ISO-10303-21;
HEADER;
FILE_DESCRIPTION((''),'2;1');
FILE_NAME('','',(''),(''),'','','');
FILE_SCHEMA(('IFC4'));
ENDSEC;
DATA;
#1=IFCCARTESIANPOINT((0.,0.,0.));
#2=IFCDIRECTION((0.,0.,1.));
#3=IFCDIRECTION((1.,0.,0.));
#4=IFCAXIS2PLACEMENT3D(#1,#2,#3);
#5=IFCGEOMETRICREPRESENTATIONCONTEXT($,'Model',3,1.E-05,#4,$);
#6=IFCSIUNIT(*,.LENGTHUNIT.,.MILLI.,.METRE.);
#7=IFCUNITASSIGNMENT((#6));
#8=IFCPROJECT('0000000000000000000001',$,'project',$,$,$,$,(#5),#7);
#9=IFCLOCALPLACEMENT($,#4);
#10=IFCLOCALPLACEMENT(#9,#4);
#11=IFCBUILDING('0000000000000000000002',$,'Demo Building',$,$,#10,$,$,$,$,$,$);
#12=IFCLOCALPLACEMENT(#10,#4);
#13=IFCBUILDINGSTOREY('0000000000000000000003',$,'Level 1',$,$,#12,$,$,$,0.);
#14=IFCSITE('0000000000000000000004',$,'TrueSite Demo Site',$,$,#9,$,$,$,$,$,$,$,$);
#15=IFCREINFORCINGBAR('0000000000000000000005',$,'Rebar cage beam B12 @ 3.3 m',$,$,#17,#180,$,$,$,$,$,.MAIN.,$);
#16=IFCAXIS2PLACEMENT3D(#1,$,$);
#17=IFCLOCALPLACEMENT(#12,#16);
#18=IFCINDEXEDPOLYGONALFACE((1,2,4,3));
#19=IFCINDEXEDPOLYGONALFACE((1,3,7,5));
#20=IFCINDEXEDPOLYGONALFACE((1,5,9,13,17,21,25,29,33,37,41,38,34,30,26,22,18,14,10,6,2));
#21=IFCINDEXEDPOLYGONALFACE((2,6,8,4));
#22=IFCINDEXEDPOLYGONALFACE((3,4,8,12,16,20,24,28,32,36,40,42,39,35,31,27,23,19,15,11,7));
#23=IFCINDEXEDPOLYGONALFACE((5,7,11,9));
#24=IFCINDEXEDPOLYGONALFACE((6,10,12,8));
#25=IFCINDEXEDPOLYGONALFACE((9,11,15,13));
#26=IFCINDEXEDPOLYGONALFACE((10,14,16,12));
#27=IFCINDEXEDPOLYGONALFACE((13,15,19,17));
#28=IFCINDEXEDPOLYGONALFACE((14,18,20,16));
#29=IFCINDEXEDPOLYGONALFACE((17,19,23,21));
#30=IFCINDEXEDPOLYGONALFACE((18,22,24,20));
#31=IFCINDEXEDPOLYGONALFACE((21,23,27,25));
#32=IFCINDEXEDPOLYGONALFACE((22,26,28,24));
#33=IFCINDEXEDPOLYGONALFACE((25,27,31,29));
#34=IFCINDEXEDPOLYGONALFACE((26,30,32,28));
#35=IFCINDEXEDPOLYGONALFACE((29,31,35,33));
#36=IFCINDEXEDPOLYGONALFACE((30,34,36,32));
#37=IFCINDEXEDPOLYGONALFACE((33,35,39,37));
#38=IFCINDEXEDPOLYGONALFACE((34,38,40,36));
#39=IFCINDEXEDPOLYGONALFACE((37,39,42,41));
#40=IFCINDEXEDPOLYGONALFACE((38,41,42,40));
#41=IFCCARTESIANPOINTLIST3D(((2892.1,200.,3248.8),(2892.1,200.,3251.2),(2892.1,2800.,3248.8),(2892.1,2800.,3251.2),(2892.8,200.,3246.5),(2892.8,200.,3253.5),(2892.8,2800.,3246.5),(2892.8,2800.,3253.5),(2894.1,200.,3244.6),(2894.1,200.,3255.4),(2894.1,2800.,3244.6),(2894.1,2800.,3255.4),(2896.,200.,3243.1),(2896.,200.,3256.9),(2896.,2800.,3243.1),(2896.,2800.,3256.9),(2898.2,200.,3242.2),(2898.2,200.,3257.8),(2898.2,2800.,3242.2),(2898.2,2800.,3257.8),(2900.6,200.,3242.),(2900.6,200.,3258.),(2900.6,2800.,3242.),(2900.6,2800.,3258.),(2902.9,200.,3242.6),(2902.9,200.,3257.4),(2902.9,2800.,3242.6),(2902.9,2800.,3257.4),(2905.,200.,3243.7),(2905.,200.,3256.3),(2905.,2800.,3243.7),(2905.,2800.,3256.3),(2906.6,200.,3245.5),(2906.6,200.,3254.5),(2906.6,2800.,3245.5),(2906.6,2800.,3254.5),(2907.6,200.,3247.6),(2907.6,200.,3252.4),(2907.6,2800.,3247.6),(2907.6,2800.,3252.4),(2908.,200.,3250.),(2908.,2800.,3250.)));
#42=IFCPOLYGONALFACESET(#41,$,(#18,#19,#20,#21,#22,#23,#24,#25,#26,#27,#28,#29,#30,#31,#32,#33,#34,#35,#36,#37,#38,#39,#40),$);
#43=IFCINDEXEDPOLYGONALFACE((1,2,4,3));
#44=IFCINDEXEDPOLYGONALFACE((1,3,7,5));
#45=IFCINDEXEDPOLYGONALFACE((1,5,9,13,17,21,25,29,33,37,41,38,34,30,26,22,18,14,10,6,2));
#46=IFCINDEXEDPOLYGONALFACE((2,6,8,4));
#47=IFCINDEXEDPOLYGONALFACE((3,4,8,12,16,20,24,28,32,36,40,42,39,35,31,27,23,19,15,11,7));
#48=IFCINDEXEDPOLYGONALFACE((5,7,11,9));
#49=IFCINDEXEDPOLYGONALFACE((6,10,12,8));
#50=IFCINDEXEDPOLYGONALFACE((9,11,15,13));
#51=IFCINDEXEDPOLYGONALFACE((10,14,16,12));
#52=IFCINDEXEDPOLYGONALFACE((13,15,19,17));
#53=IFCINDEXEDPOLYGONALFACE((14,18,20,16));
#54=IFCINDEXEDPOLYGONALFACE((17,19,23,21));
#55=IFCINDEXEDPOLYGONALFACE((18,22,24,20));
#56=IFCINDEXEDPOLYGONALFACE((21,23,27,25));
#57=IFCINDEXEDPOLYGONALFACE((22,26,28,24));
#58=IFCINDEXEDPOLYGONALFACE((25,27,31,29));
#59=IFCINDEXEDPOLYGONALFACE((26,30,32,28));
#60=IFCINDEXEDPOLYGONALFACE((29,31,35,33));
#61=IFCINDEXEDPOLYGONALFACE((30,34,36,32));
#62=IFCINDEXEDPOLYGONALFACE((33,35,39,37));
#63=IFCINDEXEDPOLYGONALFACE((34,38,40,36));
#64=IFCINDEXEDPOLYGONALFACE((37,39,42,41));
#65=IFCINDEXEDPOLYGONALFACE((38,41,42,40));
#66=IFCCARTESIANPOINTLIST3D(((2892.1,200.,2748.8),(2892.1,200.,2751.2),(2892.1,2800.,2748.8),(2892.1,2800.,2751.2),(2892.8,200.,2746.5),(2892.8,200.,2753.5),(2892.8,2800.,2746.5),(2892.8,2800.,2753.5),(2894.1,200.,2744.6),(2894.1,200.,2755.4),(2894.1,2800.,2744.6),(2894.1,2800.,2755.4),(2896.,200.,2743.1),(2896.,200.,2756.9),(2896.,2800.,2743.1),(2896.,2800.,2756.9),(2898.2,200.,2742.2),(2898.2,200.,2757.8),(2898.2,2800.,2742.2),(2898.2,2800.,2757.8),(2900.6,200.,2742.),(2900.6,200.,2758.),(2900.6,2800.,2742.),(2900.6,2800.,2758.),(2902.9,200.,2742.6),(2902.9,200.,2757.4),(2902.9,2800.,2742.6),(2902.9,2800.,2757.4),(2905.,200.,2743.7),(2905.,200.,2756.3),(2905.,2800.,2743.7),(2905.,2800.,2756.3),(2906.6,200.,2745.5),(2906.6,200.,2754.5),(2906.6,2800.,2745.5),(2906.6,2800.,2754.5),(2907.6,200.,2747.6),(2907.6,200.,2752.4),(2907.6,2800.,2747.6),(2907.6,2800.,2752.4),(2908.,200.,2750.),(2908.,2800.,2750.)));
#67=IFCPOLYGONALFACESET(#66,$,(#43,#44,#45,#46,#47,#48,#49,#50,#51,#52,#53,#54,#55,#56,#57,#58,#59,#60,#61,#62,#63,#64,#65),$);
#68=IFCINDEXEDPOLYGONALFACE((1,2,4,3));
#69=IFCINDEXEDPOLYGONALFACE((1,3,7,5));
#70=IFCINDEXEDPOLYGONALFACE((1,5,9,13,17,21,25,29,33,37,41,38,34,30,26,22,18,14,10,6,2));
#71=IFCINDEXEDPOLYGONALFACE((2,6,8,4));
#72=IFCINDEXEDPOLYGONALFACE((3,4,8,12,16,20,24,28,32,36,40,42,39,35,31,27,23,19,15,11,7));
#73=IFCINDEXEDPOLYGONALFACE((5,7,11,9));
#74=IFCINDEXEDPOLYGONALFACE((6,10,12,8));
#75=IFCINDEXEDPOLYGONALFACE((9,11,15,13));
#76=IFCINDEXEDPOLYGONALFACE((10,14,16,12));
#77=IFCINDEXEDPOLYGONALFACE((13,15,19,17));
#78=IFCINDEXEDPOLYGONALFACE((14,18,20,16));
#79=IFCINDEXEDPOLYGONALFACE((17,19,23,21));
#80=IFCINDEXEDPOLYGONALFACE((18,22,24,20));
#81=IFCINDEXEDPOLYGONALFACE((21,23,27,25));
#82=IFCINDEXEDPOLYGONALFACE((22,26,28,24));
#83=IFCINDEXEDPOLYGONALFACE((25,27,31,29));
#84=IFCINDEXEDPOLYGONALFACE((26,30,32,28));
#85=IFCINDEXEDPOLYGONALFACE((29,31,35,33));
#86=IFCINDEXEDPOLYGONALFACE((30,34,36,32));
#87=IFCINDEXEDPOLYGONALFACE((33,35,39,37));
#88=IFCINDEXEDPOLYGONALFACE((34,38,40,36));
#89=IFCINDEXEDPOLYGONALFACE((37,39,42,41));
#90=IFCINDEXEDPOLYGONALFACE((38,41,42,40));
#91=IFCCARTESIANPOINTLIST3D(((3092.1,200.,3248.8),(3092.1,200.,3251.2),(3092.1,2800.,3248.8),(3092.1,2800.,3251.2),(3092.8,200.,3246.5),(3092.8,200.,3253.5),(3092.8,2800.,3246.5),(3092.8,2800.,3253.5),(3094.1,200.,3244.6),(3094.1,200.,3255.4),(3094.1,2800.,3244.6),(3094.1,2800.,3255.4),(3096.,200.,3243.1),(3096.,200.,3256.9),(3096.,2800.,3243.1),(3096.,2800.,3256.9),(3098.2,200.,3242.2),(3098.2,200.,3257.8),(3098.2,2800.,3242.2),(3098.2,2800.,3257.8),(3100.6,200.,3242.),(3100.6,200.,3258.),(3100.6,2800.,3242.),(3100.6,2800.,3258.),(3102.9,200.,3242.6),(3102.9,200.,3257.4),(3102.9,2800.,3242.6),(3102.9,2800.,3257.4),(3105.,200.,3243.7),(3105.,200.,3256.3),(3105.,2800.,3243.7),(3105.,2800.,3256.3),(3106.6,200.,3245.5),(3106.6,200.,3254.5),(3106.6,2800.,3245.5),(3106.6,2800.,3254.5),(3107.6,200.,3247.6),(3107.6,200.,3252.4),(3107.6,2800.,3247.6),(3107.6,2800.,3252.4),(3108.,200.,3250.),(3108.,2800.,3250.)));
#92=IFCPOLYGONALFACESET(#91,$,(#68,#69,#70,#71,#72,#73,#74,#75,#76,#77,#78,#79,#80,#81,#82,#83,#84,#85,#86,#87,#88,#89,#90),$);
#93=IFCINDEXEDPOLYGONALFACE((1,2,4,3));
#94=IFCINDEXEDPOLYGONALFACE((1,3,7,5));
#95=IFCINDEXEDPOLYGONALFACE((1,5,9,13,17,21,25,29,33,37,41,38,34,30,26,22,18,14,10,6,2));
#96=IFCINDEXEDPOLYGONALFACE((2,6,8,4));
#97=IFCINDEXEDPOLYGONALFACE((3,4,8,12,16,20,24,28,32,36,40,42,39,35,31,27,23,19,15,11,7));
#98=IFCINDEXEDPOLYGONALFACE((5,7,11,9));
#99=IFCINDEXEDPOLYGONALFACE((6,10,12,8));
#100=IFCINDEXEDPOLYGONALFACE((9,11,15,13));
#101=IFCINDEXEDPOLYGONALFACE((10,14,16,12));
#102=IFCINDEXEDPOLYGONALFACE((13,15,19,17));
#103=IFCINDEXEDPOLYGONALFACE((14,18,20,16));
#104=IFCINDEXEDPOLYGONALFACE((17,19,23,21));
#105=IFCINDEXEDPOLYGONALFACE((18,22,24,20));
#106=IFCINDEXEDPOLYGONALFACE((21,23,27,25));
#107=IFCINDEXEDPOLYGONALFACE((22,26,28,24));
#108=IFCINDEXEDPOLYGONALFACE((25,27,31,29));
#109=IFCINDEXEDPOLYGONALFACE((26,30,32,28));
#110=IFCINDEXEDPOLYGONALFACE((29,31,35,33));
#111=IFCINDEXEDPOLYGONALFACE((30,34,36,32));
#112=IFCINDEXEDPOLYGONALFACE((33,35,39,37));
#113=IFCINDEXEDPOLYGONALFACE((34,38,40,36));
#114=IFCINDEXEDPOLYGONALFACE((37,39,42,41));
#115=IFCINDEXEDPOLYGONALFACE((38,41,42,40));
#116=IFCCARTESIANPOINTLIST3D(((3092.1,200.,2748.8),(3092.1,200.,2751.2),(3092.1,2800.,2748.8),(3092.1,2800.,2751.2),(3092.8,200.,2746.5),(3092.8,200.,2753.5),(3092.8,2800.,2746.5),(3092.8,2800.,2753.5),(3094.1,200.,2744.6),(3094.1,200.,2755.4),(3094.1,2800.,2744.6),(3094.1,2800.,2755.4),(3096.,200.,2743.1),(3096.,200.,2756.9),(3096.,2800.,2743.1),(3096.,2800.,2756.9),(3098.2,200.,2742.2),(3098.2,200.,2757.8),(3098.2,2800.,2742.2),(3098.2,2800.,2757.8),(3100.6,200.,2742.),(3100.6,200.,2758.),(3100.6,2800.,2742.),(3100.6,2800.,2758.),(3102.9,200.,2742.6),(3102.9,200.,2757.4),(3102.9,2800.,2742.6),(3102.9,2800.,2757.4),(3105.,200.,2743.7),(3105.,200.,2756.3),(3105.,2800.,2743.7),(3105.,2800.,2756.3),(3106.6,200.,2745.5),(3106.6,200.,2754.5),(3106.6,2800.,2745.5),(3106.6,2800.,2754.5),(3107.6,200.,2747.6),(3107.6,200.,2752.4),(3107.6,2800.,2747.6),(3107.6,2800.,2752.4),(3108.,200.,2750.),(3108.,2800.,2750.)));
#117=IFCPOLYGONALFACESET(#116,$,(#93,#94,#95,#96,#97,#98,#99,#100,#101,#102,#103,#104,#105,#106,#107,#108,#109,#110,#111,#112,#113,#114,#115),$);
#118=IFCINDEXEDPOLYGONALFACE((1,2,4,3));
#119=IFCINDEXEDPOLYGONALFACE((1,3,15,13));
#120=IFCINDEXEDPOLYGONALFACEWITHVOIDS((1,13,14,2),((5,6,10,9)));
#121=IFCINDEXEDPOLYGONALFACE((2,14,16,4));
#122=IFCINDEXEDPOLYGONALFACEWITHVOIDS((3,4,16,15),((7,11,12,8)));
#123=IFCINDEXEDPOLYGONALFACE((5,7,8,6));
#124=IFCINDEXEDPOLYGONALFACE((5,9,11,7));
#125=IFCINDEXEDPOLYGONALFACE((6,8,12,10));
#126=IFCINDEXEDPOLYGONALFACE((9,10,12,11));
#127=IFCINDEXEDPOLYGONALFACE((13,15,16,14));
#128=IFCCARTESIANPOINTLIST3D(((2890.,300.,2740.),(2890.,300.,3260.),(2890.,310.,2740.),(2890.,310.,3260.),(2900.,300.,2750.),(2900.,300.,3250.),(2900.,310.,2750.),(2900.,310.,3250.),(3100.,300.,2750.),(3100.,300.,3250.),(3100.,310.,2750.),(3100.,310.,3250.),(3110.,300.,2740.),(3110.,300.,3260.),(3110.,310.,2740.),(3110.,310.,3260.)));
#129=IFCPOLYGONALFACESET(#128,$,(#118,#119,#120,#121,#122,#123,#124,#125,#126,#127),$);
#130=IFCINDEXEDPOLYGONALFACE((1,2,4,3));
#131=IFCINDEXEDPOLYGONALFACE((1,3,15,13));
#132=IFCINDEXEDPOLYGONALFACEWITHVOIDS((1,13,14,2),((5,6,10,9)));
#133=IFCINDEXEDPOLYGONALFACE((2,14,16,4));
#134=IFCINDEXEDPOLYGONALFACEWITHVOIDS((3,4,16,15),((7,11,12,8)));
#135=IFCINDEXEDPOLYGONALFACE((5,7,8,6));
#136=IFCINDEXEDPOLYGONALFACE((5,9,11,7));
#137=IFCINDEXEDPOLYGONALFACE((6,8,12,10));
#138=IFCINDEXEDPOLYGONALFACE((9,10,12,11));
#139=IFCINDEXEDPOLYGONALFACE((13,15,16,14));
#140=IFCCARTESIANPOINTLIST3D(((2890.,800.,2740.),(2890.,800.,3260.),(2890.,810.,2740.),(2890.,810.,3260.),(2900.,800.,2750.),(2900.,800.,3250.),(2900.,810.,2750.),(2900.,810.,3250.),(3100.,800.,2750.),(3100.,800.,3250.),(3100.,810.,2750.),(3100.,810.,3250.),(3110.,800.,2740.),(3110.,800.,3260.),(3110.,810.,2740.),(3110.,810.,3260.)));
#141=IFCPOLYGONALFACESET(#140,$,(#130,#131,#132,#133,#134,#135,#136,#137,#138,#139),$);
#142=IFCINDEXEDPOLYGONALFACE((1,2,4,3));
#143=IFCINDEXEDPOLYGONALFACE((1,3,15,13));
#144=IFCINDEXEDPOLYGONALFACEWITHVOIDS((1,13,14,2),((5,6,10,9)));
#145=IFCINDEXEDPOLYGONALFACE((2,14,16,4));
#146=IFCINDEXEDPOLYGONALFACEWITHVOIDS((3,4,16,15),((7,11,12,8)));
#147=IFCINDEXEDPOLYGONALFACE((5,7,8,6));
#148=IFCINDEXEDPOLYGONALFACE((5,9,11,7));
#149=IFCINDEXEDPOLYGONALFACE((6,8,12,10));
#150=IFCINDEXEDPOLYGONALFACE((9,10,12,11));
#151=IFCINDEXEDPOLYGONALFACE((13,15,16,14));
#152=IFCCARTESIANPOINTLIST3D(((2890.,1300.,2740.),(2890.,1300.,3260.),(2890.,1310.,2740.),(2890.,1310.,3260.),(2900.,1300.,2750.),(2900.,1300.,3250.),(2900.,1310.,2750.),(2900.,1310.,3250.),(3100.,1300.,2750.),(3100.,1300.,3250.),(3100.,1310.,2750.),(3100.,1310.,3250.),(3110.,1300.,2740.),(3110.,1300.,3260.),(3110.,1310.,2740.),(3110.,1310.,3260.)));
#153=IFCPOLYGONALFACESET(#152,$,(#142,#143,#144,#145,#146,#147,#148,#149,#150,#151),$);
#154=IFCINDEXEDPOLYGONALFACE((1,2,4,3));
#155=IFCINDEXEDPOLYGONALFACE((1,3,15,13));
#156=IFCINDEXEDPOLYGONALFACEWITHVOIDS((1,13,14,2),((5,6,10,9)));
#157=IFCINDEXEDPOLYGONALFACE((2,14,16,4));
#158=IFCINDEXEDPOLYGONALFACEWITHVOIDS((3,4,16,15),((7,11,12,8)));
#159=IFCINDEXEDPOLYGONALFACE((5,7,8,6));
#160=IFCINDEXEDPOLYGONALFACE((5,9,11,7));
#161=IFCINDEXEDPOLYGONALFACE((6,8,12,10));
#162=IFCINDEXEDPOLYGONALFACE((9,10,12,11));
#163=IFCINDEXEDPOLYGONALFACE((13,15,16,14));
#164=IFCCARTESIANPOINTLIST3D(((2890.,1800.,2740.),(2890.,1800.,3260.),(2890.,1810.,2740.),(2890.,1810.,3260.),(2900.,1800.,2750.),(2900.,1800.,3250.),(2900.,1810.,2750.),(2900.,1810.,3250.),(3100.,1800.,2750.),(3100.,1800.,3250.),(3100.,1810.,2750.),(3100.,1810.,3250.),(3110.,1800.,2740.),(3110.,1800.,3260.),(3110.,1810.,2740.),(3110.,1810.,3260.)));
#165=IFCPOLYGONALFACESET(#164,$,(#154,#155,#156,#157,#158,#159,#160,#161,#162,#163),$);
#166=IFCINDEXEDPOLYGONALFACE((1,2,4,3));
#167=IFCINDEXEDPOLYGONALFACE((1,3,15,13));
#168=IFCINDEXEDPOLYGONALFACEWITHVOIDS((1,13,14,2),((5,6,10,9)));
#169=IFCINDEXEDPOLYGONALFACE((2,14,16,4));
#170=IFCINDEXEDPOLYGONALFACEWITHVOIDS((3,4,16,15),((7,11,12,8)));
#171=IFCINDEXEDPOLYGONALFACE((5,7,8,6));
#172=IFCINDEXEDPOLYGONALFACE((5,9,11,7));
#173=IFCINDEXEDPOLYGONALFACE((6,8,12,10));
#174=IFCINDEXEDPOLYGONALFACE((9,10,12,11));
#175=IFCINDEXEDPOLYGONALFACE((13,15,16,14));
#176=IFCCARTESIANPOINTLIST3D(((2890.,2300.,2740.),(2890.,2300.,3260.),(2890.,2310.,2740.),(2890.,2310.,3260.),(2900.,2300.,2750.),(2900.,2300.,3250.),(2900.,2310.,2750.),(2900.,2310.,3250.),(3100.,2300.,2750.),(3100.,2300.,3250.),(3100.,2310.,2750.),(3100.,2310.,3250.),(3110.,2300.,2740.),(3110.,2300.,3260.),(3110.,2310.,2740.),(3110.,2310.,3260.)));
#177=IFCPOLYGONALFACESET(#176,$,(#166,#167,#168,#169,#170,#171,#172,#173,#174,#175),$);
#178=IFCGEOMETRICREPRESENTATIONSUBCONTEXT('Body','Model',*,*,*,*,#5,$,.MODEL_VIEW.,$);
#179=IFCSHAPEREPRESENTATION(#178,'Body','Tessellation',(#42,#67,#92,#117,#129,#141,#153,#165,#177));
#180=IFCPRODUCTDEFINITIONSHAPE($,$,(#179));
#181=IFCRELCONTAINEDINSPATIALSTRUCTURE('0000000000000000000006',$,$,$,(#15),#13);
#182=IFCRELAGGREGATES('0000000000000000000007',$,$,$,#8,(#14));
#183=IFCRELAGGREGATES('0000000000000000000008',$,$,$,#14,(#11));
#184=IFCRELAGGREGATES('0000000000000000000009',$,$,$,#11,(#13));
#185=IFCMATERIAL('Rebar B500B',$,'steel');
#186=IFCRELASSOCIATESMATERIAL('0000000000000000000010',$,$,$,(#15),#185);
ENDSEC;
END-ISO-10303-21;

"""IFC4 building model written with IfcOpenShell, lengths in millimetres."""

from ifc_helpers import new_model, si_unit, frame, origin_with_axes, place, context, subcontext, project, spatial, hollow_rectangle, circle, extrude, material, element, save


model = new_model("IFC4")

# Units and contexts
model_context = context("Model", 3, precision=1e-05, world=origin_with_axes())
body_context = subcontext(model_context, "Body", "Model", "MODEL_VIEW")
ifc_project = project(units=[si_unit("LENGTHUNIT", "METRE", prefix="MILLI")], contexts=[model_context])

# Site, building, storey
site_placement = place(None, origin_with_axes())
site = spatial("IfcSite", under=ifc_project, at=site_placement, Name="TrueSite Demo Site")
building_placement = place(site_placement, origin_with_axes())
building = spatial("IfcBuilding", under=site, at=building_placement, Name="Demo Building")
storey_placement = place(building_placement, origin_with_axes())
storey = spatial("IfcBuildingStorey", under=building, at=storey_placement, Name="Level 1", Elevation=0.0)

# Reinforcing bar
ifc_material_1 = material(Name="Rebar B500B", Category="steel")
for number, where, z_axis, x_axis, name in (
    (1, (3000.0, 200.0, 3000.0), (0.0, 1.0, 0.0), (1.0, 0.0, 0.0), "Rebar cage beam B12 @ 3.3 m"),
):
    element("IfcReinforcingBar", number, at=place(storey_placement, frame(where, z_axis=z_axis, x_axis=x_axis)), inside=storey, material=ifc_material_1, Name=name, PredefinedType="MAIN", context=body_context, shape_type="SweptSolid", body=[
        extrude(circle(Radius=8.0), frame((-100.0, -250.0, 0.0)), (0.0, 0.0, 1.0), 2600.0),
        extrude(circle(Radius=8.0), frame((-100.0, 250.0, 0.0)), (0.0, 0.0, 1.0), 2600.0),
        extrude(circle(Radius=8.0), frame((100.0, -250.0, 0.0)), (0.0, 0.0, 1.0), 2600.0),
        extrude(circle(Radius=8.0), frame((100.0, 250.0, 0.0)), (0.0, 0.0, 1.0), 2600.0),
        extrude(hollow_rectangle(XDim=220.0, YDim=520.0, WallThickness=10.0), frame((0.0, 0.0, 100.0)), (0.0, 0.0, 1.0), 10.0),
        extrude(hollow_rectangle(XDim=220.0, YDim=520.0, WallThickness=10.0), frame((0.0, 0.0, 600.0)), (0.0, 0.0, 1.0), 10.0),
        extrude(hollow_rectangle(XDim=220.0, YDim=520.0, WallThickness=10.0), frame((0.0, 0.0, 1100.0)), (0.0, 0.0, 1.0), 10.0),
        extrude(hollow_rectangle(XDim=220.0, YDim=520.0, WallThickness=10.0), frame((0.0, 0.0, 1600.0)), (0.0, 0.0, 1.0), 10.0),
        extrude(hollow_rectangle(XDim=220.0, YDim=520.0, WallThickness=10.0), frame((0.0, 0.0, 2100.0)), (0.0, 0.0, 1.0), 10.0),
    ])

save(model, "model.ifc")
